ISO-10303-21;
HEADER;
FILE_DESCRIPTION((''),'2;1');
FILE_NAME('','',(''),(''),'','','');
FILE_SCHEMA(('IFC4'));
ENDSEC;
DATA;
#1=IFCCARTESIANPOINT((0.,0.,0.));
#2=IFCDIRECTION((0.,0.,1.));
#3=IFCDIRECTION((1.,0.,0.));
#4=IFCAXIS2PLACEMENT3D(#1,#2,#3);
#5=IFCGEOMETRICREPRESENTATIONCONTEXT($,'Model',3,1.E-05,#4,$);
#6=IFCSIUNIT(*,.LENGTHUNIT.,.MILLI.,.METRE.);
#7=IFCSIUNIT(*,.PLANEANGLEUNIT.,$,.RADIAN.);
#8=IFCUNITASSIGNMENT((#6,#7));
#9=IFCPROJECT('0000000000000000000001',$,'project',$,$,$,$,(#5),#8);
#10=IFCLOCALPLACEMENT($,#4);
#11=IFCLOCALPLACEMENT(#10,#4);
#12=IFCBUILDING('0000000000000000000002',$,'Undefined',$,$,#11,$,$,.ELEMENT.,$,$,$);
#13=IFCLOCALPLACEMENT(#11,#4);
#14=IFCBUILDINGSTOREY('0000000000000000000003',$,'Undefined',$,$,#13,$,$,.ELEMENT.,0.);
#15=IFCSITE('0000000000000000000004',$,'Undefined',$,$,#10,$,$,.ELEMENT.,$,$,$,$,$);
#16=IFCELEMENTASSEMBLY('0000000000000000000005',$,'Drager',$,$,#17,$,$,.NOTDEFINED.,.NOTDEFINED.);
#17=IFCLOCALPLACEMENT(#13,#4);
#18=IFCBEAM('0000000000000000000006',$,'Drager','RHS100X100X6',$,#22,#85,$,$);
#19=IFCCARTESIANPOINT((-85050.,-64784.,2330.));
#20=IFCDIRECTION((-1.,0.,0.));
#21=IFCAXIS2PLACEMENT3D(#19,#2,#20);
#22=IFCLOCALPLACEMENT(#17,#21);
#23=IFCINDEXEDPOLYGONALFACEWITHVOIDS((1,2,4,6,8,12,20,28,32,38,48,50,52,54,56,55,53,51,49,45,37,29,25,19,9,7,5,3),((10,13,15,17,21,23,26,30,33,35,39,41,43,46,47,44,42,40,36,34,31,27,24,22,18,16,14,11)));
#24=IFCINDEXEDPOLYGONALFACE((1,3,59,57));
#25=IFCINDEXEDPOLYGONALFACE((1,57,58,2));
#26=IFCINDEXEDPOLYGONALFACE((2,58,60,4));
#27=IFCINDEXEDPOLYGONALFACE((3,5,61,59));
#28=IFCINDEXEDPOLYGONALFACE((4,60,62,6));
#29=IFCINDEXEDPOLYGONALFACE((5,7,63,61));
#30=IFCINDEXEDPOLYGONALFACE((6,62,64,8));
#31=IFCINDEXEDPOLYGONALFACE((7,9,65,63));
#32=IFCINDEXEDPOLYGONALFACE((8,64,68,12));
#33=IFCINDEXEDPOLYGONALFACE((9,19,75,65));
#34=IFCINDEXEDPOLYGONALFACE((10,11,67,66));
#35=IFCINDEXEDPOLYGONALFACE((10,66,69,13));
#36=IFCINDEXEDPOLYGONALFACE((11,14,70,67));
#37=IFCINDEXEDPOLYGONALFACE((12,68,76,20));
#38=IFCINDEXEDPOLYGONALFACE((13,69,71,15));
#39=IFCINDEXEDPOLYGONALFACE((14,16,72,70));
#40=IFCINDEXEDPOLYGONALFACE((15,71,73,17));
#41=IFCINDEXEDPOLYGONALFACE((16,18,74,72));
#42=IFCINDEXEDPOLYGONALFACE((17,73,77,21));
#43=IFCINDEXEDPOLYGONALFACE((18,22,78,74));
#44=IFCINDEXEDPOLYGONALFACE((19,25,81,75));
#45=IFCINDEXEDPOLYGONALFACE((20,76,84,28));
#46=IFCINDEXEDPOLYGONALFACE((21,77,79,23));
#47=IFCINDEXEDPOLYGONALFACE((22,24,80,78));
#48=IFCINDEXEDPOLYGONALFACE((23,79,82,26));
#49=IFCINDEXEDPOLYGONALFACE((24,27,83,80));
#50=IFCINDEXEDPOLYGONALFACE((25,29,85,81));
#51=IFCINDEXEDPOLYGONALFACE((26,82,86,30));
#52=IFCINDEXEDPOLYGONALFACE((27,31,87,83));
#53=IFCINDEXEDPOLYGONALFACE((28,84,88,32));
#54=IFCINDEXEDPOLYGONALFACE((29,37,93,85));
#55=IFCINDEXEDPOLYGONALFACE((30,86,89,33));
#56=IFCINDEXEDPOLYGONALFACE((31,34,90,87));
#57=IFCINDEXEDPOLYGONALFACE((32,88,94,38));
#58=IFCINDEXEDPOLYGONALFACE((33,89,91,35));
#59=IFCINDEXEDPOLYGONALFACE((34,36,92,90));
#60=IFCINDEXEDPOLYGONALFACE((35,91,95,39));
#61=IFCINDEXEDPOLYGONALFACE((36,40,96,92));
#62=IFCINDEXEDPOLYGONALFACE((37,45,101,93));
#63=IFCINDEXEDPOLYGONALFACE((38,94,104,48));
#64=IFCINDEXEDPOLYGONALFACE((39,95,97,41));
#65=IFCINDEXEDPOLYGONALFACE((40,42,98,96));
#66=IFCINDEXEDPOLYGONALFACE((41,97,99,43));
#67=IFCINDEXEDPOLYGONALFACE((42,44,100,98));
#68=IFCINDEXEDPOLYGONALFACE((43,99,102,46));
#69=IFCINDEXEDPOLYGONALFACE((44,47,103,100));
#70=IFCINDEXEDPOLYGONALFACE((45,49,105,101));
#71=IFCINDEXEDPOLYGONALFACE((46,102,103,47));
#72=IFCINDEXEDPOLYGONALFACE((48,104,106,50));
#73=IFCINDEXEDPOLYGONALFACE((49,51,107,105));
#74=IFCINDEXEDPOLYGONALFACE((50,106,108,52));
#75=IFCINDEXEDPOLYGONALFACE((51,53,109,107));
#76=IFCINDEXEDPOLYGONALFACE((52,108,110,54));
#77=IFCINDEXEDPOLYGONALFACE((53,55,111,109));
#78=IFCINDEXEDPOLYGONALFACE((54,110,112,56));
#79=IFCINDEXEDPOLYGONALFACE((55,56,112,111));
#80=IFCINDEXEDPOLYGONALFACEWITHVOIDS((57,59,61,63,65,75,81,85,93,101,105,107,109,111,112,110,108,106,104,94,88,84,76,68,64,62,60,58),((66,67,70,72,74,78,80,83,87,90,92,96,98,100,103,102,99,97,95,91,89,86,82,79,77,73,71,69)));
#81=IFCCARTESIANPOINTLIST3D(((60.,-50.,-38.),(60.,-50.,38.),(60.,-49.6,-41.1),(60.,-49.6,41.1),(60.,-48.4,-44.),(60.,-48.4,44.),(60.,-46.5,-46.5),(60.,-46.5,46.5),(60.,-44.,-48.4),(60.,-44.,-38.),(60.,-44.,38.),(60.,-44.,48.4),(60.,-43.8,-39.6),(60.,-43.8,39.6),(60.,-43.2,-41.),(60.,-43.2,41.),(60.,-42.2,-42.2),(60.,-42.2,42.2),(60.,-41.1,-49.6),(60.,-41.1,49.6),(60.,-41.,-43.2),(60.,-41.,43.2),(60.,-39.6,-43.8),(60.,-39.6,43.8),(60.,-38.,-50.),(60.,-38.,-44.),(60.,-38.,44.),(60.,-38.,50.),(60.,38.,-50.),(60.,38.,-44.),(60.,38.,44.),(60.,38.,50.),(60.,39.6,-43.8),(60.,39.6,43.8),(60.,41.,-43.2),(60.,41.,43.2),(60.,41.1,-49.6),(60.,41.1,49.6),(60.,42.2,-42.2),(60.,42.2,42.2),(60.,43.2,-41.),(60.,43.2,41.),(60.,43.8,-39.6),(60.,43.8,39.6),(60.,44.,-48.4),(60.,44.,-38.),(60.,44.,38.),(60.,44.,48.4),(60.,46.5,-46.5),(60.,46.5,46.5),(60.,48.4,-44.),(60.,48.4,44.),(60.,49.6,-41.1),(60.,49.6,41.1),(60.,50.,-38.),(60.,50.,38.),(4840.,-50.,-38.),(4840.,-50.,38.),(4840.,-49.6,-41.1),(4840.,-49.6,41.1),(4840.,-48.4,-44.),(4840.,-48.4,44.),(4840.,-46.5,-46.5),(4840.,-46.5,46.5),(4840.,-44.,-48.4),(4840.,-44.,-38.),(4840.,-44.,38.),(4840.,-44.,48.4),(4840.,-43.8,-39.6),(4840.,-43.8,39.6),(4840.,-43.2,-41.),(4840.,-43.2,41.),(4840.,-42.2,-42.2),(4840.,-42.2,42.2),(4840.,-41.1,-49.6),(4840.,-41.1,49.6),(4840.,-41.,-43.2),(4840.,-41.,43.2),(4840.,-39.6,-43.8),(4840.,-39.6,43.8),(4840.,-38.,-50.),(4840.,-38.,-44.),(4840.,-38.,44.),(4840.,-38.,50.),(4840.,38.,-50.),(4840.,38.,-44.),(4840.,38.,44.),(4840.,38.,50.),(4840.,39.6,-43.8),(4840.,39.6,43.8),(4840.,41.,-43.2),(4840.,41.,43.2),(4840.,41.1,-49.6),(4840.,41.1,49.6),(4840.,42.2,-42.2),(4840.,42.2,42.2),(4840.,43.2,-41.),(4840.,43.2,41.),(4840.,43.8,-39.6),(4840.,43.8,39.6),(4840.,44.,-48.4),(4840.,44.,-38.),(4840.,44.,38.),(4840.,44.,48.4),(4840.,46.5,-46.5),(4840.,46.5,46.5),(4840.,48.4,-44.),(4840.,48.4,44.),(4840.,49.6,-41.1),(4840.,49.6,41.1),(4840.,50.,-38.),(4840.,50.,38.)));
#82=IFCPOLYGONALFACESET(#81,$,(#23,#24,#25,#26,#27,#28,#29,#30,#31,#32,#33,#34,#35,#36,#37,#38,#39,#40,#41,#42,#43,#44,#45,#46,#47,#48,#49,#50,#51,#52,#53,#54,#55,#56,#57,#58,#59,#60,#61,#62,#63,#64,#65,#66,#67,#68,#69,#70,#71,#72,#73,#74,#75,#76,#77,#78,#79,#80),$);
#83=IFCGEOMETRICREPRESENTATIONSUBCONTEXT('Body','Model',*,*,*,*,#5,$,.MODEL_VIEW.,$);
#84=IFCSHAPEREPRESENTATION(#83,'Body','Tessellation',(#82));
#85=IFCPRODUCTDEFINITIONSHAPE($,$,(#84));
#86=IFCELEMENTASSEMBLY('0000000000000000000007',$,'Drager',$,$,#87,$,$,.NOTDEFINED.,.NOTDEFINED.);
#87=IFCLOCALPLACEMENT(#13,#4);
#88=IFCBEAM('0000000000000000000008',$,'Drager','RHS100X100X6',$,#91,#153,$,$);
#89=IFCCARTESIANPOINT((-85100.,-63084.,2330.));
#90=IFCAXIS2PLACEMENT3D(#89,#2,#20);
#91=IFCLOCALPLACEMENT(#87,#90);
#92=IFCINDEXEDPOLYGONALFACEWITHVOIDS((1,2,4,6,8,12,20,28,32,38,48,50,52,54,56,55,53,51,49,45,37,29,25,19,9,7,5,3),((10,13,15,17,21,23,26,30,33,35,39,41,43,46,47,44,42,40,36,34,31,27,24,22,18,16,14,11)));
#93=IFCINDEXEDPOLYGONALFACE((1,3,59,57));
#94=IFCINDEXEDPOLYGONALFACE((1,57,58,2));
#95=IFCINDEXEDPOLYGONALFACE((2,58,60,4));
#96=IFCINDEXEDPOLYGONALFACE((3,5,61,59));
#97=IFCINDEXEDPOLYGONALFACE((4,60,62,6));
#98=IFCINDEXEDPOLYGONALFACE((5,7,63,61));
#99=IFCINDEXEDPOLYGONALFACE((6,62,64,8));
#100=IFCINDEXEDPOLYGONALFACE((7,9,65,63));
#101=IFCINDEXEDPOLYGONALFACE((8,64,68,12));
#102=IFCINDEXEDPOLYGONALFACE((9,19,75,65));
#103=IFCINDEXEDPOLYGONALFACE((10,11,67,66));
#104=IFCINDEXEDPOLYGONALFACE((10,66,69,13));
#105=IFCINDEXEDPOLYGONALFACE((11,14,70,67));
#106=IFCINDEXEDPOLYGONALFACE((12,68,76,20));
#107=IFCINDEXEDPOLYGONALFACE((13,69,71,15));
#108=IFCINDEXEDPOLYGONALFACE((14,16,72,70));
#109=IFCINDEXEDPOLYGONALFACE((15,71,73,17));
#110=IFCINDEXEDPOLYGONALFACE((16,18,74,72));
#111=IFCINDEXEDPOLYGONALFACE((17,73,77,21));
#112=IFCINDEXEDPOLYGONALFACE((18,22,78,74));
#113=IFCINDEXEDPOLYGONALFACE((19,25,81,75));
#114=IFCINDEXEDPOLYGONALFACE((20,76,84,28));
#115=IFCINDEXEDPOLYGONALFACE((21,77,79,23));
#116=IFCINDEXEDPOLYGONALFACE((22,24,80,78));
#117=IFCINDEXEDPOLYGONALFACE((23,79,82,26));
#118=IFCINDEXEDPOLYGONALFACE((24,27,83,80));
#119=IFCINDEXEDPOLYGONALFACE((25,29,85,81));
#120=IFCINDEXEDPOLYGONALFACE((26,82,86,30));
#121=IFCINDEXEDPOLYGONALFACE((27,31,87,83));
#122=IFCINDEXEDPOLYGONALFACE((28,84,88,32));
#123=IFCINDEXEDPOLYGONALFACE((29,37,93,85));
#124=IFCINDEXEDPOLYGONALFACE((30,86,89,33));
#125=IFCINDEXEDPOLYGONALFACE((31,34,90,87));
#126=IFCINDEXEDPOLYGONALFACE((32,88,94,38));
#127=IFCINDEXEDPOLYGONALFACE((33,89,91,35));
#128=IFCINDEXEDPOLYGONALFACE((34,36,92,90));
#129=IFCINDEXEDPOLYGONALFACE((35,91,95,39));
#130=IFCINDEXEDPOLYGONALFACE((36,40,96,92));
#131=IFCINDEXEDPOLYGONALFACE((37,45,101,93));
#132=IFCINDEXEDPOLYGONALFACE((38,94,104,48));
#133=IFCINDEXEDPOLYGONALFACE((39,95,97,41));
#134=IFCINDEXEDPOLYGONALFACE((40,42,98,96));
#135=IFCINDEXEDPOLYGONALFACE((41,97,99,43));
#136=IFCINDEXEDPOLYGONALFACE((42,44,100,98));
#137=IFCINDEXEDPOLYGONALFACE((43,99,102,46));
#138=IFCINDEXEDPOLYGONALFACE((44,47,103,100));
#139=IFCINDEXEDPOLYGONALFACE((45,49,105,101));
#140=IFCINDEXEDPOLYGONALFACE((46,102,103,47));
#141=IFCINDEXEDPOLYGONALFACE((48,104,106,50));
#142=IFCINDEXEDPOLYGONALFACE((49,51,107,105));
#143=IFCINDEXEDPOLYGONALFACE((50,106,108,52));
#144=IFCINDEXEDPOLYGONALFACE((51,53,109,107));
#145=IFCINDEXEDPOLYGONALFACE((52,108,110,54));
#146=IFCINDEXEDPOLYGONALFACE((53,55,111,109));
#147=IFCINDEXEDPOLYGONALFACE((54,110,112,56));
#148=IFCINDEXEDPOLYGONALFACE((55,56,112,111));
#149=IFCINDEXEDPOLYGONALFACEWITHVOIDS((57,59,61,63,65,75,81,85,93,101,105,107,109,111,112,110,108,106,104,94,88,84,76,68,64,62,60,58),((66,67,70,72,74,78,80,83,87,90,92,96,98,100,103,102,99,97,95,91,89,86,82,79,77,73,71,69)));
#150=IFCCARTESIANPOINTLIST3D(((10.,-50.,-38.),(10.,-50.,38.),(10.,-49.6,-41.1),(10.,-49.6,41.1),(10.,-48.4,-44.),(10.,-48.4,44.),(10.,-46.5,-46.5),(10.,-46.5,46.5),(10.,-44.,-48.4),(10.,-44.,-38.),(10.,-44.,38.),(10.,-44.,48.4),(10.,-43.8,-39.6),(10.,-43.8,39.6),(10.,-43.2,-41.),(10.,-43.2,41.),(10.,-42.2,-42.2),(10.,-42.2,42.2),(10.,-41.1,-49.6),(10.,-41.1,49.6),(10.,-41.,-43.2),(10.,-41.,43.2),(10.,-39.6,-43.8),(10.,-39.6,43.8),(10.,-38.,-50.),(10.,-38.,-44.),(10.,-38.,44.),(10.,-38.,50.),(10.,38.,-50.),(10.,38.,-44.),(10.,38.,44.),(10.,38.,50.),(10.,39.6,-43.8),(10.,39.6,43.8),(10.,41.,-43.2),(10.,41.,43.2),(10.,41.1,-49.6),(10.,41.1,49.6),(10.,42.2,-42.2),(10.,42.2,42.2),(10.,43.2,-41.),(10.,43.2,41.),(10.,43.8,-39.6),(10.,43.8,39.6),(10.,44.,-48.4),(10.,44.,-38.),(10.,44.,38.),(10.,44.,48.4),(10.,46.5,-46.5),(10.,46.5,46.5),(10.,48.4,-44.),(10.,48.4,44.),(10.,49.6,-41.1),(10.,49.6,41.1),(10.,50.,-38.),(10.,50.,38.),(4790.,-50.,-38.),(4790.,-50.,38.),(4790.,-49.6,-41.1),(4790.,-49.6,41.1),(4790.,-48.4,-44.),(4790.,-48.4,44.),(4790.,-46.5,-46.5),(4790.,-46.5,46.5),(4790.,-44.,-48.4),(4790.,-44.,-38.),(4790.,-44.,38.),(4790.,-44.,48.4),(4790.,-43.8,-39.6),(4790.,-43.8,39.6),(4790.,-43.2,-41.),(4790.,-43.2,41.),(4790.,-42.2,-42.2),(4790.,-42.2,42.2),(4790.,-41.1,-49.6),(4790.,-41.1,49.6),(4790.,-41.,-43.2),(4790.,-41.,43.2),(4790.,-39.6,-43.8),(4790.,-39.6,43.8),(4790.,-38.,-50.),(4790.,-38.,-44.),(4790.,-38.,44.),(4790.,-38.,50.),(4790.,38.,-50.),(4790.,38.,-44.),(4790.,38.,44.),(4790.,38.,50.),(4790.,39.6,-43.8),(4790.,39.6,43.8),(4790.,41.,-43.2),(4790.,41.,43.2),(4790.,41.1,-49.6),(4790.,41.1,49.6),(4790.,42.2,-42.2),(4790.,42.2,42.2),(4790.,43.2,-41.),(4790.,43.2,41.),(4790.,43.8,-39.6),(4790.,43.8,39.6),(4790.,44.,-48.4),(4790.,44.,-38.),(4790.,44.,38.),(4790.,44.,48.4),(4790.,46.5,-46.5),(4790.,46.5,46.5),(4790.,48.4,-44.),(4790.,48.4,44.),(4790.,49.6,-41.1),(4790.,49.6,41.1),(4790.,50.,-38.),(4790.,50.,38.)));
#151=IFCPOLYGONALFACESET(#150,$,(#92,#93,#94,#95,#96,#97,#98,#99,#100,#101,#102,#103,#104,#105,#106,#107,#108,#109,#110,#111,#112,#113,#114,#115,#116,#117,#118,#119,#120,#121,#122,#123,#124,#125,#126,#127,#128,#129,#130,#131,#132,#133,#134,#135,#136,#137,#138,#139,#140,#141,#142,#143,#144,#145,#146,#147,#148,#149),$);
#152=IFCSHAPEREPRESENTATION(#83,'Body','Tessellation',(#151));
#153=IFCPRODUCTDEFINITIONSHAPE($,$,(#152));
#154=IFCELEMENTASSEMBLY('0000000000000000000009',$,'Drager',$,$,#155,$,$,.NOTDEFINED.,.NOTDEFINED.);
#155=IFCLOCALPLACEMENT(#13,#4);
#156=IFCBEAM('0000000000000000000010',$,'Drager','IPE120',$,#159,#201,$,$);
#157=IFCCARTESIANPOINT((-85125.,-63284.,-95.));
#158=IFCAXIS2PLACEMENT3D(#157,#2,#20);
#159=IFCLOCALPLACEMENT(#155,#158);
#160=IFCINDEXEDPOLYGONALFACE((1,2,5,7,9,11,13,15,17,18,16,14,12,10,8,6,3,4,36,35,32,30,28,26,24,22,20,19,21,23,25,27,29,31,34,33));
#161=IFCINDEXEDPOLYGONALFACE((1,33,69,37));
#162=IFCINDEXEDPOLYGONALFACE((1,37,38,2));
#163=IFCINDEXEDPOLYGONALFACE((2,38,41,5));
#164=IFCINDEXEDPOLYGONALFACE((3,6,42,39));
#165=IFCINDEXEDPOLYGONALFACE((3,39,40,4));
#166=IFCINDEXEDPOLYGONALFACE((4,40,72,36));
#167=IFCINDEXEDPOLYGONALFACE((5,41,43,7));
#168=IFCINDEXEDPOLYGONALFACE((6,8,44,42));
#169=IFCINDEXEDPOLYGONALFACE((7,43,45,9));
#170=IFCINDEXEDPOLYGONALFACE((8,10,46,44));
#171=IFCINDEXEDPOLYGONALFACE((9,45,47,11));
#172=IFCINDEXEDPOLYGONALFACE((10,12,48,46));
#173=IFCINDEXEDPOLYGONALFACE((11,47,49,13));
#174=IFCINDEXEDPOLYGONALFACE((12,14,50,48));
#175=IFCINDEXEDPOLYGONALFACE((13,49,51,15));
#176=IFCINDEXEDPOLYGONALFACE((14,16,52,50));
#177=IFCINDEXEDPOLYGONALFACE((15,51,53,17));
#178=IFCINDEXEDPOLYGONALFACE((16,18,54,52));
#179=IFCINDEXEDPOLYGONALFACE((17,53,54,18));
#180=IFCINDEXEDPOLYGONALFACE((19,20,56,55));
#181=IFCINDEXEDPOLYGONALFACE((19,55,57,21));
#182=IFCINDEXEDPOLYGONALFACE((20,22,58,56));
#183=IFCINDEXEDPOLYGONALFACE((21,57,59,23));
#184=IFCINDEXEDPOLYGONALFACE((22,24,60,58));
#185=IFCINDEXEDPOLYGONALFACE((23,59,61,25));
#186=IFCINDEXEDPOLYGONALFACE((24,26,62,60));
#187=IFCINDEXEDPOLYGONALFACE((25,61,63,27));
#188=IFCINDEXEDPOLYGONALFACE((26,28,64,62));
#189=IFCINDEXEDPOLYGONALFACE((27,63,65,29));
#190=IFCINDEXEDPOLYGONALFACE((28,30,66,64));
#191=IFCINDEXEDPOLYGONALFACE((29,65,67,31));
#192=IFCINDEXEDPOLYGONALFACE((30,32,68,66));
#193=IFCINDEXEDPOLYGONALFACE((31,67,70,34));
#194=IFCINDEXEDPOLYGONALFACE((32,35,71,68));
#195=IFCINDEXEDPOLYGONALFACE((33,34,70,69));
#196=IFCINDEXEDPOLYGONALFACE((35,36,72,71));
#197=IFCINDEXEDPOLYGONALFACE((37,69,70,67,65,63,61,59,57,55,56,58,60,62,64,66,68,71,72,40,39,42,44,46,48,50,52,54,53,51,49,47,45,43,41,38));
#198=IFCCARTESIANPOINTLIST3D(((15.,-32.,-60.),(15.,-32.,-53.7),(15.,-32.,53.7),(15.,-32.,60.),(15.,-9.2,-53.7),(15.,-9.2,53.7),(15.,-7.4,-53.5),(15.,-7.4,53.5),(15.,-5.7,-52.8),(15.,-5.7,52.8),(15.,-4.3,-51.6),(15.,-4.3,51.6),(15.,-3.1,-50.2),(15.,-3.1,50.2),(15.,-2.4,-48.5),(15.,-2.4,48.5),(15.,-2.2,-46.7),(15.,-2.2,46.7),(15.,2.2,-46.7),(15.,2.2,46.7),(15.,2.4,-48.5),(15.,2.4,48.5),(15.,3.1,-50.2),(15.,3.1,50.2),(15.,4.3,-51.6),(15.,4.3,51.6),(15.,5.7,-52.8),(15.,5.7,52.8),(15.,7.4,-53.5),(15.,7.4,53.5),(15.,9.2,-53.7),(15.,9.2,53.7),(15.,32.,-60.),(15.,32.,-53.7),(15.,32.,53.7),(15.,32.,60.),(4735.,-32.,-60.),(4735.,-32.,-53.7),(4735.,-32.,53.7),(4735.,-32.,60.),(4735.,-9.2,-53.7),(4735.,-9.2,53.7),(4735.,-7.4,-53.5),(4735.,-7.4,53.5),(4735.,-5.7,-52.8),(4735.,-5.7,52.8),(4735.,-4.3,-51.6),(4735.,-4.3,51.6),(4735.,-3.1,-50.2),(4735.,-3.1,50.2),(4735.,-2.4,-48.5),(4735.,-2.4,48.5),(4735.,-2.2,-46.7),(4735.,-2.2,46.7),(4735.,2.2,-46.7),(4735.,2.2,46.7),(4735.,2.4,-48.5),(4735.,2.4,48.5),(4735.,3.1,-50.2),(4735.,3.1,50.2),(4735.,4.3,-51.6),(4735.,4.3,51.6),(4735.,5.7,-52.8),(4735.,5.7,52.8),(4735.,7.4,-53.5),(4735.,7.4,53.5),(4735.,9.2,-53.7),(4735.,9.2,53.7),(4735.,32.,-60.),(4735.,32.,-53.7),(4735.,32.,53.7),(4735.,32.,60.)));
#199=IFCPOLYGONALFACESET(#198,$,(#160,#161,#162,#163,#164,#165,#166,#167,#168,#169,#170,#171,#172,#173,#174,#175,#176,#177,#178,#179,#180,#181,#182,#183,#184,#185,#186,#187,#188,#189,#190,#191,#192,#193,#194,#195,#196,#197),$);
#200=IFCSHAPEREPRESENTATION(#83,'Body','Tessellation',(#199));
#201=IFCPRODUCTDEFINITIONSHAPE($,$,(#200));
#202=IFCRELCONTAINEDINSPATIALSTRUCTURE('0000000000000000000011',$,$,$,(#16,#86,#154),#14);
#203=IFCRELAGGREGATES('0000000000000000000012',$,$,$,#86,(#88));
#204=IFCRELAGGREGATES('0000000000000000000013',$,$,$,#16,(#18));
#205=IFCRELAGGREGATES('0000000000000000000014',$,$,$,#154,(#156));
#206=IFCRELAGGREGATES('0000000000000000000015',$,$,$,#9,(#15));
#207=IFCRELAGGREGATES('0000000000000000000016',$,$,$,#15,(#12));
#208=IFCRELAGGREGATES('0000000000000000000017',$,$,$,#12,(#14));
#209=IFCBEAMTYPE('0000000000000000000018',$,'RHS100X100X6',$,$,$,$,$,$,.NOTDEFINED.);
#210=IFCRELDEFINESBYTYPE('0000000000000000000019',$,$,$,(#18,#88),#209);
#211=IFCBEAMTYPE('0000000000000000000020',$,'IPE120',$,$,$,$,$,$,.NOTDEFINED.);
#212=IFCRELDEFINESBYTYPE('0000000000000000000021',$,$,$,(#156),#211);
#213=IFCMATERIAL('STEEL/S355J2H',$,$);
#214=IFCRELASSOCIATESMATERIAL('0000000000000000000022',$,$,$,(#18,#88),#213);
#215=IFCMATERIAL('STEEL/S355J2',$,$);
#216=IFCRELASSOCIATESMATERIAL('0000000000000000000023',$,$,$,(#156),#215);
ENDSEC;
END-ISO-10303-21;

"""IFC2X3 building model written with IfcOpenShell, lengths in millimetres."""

from ifc_helpers import new_model, si_unit, frame, origin_with_axes, origin_2d_with_axis, place, context, subcontext, project, spatial, hollow_rectangle, i_section, extrude, clip, halfspace, material, type_object, element, aggregate, save


model = new_model("IFC2X3")

# Units and contexts
model_context = context("Model", 3, precision=1e-05, world=origin_with_axes())
body_context = subcontext(model_context, "Body", "Model", "MODEL_VIEW")
ifc_project = project(units=[si_unit("LENGTHUNIT", "METRE", prefix="MILLI"), si_unit("PLANEANGLEUNIT", "RADIAN")], contexts=[model_context])

# Site, building, storey
site_placement = place(None, origin_with_axes())
site = spatial("IfcSite", under=ifc_project, at=site_placement, Name="Undefined", CompositionType="ELEMENT")
building_placement = place(site_placement, origin_with_axes())
building = spatial("IfcBuilding", under=site, at=building_placement, Name="Undefined", CompositionType="ELEMENT")
storey_placement = place(building_placement, origin_with_axes())
storey = spatial("IfcBuildingStorey", under=building, at=storey_placement, Name="Undefined", CompositionType="ELEMENT", Elevation=0.0)

# Element assemblies, beams
ifc_material_1 = material(Name="STEEL/S355J2H")
beam_type_1 = type_object("IfcBeamType", Name="RHS100X100X6", PredefinedType="NOTDEFINED")
assembly_1_placement = place(storey_placement, origin_with_axes())
assembly_1 = element("IfcElementAssembly", 1, at=assembly_1_placement, inside=storey, Name="Drager", AssemblyPlace="NOTDEFINED", PredefinedType="NOTDEFINED")
beam_1_placement = place(assembly_1_placement, frame((-85050.0, -64784.0, 2330.0), z_axis=(0.0, 0.0, 1.0), x_axis=(-1.0, 0.0, 0.0)))
beam_1 = element("IfcBeam", 2, at=beam_1_placement, type_object=beam_type_1, material=ifc_material_1, Name="Drager", Description="RHS100X100X6", context=body_context, shape_type="Clipping", body=[
    clip(clip(extrude(hollow_rectangle(XDim=100.0, YDim=100.0, WallThickness=6.0, InnerFilletRadius=6.0, OuterFilletRadius=12.0, at=origin_2d_with_axis()), frame((4900.0, 0.0, 0.0), z_axis=(-1.0, 0.0, 0.0), x_axis=(0.0, -1.0, 0.0)), (0.0, 0.0, 1.0), 4900.0), halfspace(frame((4840.0, 50.0, 0.0), z_axis=(-1.0, 0.0, 0.0), x_axis=(0.0, 0.0, 1.0)), True)), halfspace(frame((60.0, 50.0, 0.0), z_axis=(1.0, 0.0, 0.0), x_axis=(0.0, 0.0, -1.0)), True)),
])
assembly_2_placement = place(storey_placement, origin_with_axes())
assembly_2 = element("IfcElementAssembly", 3, at=assembly_2_placement, inside=storey, Name="Drager", AssemblyPlace="NOTDEFINED", PredefinedType="NOTDEFINED")
beam_2_placement = place(assembly_2_placement, frame((-85100.0, -63084.0, 2330.0), z_axis=(0.0, 0.0, 1.0), x_axis=(-1.0, 0.0, 0.0)))
beam_2 = element("IfcBeam", 4, at=beam_2_placement, type_object=beam_type_1, material=ifc_material_1, Name="Drager", Description="RHS100X100X6", context=body_context, shape_type="Clipping", body=[
    clip(clip(extrude(hollow_rectangle(XDim=100.0, YDim=100.0, WallThickness=6.0, InnerFilletRadius=6.0, OuterFilletRadius=12.0, at=origin_2d_with_axis()), frame((4800.0, 0.0, 0.0), z_axis=(-1.0, 0.0, 0.0), x_axis=(0.0, -1.0, 0.0)), (0.0, 0.0, 1.0), 4800.0), halfspace(frame((4790.0, -50.0, 0.0), z_axis=(-1.0, 0.0, 0.0), x_axis=(0.0, 0.0, -1.0)), True)), halfspace(frame((10.0, -50.0, 0.0), z_axis=(1.0, 0.0, 0.0), x_axis=(0.0, 0.0, 1.0)), True)),
])

# Shared definitions
ifc_material_2 = material(Name="STEEL/S355J2")

# Element assembly, beam
assembly_3_placement = place(storey_placement, origin_with_axes())
assembly_3 = element("IfcElementAssembly", 5, at=assembly_3_placement, inside=storey, Name="Drager", AssemblyPlace="NOTDEFINED", PredefinedType="NOTDEFINED")
beam_type_2 = type_object("IfcBeamType", Name="IPE120", PredefinedType="NOTDEFINED")
beam_3_placement = place(assembly_3_placement, frame((-85125.0, -63284.0, -95.0), z_axis=(0.0, 0.0, 1.0), x_axis=(-1.0, 0.0, 0.0)))
beam_3 = element("IfcBeam", 6, at=beam_3_placement, type_object=beam_type_2, material=ifc_material_2, Name="Drager", Description="IPE120", context=body_context, shape_type="Clipping", body=[
    clip(clip(extrude(i_section(OverallWidth=64.0, OverallDepth=120.0, WebThickness=4.4, FlangeThickness=6.3, FilletRadius=7.0, at=origin_2d_with_axis()), frame((4750.0, 0.0, 0.0), z_axis=(-1.0, 0.0, 0.0), x_axis=(0.0, -1.0, 0.0)), (0.0, 0.0, 1.0), 4750.0), halfspace(frame((4735.0, 0.0, 60.0), z_axis=(-1.0, 0.0, 0.0), x_axis=(0.0, -1.0, 0.0)), True)), halfspace(frame((15.0, 0.0, -60.0), z_axis=(1.0, 0.0, 0.0), x_axis=(0.0, -1.0, 0.0)), True)),
])

aggregate(assembly_2, [beam_2])
aggregate(assembly_1, [beam_1])
aggregate(assembly_3, [beam_3])

save(model, "model.ifc")
